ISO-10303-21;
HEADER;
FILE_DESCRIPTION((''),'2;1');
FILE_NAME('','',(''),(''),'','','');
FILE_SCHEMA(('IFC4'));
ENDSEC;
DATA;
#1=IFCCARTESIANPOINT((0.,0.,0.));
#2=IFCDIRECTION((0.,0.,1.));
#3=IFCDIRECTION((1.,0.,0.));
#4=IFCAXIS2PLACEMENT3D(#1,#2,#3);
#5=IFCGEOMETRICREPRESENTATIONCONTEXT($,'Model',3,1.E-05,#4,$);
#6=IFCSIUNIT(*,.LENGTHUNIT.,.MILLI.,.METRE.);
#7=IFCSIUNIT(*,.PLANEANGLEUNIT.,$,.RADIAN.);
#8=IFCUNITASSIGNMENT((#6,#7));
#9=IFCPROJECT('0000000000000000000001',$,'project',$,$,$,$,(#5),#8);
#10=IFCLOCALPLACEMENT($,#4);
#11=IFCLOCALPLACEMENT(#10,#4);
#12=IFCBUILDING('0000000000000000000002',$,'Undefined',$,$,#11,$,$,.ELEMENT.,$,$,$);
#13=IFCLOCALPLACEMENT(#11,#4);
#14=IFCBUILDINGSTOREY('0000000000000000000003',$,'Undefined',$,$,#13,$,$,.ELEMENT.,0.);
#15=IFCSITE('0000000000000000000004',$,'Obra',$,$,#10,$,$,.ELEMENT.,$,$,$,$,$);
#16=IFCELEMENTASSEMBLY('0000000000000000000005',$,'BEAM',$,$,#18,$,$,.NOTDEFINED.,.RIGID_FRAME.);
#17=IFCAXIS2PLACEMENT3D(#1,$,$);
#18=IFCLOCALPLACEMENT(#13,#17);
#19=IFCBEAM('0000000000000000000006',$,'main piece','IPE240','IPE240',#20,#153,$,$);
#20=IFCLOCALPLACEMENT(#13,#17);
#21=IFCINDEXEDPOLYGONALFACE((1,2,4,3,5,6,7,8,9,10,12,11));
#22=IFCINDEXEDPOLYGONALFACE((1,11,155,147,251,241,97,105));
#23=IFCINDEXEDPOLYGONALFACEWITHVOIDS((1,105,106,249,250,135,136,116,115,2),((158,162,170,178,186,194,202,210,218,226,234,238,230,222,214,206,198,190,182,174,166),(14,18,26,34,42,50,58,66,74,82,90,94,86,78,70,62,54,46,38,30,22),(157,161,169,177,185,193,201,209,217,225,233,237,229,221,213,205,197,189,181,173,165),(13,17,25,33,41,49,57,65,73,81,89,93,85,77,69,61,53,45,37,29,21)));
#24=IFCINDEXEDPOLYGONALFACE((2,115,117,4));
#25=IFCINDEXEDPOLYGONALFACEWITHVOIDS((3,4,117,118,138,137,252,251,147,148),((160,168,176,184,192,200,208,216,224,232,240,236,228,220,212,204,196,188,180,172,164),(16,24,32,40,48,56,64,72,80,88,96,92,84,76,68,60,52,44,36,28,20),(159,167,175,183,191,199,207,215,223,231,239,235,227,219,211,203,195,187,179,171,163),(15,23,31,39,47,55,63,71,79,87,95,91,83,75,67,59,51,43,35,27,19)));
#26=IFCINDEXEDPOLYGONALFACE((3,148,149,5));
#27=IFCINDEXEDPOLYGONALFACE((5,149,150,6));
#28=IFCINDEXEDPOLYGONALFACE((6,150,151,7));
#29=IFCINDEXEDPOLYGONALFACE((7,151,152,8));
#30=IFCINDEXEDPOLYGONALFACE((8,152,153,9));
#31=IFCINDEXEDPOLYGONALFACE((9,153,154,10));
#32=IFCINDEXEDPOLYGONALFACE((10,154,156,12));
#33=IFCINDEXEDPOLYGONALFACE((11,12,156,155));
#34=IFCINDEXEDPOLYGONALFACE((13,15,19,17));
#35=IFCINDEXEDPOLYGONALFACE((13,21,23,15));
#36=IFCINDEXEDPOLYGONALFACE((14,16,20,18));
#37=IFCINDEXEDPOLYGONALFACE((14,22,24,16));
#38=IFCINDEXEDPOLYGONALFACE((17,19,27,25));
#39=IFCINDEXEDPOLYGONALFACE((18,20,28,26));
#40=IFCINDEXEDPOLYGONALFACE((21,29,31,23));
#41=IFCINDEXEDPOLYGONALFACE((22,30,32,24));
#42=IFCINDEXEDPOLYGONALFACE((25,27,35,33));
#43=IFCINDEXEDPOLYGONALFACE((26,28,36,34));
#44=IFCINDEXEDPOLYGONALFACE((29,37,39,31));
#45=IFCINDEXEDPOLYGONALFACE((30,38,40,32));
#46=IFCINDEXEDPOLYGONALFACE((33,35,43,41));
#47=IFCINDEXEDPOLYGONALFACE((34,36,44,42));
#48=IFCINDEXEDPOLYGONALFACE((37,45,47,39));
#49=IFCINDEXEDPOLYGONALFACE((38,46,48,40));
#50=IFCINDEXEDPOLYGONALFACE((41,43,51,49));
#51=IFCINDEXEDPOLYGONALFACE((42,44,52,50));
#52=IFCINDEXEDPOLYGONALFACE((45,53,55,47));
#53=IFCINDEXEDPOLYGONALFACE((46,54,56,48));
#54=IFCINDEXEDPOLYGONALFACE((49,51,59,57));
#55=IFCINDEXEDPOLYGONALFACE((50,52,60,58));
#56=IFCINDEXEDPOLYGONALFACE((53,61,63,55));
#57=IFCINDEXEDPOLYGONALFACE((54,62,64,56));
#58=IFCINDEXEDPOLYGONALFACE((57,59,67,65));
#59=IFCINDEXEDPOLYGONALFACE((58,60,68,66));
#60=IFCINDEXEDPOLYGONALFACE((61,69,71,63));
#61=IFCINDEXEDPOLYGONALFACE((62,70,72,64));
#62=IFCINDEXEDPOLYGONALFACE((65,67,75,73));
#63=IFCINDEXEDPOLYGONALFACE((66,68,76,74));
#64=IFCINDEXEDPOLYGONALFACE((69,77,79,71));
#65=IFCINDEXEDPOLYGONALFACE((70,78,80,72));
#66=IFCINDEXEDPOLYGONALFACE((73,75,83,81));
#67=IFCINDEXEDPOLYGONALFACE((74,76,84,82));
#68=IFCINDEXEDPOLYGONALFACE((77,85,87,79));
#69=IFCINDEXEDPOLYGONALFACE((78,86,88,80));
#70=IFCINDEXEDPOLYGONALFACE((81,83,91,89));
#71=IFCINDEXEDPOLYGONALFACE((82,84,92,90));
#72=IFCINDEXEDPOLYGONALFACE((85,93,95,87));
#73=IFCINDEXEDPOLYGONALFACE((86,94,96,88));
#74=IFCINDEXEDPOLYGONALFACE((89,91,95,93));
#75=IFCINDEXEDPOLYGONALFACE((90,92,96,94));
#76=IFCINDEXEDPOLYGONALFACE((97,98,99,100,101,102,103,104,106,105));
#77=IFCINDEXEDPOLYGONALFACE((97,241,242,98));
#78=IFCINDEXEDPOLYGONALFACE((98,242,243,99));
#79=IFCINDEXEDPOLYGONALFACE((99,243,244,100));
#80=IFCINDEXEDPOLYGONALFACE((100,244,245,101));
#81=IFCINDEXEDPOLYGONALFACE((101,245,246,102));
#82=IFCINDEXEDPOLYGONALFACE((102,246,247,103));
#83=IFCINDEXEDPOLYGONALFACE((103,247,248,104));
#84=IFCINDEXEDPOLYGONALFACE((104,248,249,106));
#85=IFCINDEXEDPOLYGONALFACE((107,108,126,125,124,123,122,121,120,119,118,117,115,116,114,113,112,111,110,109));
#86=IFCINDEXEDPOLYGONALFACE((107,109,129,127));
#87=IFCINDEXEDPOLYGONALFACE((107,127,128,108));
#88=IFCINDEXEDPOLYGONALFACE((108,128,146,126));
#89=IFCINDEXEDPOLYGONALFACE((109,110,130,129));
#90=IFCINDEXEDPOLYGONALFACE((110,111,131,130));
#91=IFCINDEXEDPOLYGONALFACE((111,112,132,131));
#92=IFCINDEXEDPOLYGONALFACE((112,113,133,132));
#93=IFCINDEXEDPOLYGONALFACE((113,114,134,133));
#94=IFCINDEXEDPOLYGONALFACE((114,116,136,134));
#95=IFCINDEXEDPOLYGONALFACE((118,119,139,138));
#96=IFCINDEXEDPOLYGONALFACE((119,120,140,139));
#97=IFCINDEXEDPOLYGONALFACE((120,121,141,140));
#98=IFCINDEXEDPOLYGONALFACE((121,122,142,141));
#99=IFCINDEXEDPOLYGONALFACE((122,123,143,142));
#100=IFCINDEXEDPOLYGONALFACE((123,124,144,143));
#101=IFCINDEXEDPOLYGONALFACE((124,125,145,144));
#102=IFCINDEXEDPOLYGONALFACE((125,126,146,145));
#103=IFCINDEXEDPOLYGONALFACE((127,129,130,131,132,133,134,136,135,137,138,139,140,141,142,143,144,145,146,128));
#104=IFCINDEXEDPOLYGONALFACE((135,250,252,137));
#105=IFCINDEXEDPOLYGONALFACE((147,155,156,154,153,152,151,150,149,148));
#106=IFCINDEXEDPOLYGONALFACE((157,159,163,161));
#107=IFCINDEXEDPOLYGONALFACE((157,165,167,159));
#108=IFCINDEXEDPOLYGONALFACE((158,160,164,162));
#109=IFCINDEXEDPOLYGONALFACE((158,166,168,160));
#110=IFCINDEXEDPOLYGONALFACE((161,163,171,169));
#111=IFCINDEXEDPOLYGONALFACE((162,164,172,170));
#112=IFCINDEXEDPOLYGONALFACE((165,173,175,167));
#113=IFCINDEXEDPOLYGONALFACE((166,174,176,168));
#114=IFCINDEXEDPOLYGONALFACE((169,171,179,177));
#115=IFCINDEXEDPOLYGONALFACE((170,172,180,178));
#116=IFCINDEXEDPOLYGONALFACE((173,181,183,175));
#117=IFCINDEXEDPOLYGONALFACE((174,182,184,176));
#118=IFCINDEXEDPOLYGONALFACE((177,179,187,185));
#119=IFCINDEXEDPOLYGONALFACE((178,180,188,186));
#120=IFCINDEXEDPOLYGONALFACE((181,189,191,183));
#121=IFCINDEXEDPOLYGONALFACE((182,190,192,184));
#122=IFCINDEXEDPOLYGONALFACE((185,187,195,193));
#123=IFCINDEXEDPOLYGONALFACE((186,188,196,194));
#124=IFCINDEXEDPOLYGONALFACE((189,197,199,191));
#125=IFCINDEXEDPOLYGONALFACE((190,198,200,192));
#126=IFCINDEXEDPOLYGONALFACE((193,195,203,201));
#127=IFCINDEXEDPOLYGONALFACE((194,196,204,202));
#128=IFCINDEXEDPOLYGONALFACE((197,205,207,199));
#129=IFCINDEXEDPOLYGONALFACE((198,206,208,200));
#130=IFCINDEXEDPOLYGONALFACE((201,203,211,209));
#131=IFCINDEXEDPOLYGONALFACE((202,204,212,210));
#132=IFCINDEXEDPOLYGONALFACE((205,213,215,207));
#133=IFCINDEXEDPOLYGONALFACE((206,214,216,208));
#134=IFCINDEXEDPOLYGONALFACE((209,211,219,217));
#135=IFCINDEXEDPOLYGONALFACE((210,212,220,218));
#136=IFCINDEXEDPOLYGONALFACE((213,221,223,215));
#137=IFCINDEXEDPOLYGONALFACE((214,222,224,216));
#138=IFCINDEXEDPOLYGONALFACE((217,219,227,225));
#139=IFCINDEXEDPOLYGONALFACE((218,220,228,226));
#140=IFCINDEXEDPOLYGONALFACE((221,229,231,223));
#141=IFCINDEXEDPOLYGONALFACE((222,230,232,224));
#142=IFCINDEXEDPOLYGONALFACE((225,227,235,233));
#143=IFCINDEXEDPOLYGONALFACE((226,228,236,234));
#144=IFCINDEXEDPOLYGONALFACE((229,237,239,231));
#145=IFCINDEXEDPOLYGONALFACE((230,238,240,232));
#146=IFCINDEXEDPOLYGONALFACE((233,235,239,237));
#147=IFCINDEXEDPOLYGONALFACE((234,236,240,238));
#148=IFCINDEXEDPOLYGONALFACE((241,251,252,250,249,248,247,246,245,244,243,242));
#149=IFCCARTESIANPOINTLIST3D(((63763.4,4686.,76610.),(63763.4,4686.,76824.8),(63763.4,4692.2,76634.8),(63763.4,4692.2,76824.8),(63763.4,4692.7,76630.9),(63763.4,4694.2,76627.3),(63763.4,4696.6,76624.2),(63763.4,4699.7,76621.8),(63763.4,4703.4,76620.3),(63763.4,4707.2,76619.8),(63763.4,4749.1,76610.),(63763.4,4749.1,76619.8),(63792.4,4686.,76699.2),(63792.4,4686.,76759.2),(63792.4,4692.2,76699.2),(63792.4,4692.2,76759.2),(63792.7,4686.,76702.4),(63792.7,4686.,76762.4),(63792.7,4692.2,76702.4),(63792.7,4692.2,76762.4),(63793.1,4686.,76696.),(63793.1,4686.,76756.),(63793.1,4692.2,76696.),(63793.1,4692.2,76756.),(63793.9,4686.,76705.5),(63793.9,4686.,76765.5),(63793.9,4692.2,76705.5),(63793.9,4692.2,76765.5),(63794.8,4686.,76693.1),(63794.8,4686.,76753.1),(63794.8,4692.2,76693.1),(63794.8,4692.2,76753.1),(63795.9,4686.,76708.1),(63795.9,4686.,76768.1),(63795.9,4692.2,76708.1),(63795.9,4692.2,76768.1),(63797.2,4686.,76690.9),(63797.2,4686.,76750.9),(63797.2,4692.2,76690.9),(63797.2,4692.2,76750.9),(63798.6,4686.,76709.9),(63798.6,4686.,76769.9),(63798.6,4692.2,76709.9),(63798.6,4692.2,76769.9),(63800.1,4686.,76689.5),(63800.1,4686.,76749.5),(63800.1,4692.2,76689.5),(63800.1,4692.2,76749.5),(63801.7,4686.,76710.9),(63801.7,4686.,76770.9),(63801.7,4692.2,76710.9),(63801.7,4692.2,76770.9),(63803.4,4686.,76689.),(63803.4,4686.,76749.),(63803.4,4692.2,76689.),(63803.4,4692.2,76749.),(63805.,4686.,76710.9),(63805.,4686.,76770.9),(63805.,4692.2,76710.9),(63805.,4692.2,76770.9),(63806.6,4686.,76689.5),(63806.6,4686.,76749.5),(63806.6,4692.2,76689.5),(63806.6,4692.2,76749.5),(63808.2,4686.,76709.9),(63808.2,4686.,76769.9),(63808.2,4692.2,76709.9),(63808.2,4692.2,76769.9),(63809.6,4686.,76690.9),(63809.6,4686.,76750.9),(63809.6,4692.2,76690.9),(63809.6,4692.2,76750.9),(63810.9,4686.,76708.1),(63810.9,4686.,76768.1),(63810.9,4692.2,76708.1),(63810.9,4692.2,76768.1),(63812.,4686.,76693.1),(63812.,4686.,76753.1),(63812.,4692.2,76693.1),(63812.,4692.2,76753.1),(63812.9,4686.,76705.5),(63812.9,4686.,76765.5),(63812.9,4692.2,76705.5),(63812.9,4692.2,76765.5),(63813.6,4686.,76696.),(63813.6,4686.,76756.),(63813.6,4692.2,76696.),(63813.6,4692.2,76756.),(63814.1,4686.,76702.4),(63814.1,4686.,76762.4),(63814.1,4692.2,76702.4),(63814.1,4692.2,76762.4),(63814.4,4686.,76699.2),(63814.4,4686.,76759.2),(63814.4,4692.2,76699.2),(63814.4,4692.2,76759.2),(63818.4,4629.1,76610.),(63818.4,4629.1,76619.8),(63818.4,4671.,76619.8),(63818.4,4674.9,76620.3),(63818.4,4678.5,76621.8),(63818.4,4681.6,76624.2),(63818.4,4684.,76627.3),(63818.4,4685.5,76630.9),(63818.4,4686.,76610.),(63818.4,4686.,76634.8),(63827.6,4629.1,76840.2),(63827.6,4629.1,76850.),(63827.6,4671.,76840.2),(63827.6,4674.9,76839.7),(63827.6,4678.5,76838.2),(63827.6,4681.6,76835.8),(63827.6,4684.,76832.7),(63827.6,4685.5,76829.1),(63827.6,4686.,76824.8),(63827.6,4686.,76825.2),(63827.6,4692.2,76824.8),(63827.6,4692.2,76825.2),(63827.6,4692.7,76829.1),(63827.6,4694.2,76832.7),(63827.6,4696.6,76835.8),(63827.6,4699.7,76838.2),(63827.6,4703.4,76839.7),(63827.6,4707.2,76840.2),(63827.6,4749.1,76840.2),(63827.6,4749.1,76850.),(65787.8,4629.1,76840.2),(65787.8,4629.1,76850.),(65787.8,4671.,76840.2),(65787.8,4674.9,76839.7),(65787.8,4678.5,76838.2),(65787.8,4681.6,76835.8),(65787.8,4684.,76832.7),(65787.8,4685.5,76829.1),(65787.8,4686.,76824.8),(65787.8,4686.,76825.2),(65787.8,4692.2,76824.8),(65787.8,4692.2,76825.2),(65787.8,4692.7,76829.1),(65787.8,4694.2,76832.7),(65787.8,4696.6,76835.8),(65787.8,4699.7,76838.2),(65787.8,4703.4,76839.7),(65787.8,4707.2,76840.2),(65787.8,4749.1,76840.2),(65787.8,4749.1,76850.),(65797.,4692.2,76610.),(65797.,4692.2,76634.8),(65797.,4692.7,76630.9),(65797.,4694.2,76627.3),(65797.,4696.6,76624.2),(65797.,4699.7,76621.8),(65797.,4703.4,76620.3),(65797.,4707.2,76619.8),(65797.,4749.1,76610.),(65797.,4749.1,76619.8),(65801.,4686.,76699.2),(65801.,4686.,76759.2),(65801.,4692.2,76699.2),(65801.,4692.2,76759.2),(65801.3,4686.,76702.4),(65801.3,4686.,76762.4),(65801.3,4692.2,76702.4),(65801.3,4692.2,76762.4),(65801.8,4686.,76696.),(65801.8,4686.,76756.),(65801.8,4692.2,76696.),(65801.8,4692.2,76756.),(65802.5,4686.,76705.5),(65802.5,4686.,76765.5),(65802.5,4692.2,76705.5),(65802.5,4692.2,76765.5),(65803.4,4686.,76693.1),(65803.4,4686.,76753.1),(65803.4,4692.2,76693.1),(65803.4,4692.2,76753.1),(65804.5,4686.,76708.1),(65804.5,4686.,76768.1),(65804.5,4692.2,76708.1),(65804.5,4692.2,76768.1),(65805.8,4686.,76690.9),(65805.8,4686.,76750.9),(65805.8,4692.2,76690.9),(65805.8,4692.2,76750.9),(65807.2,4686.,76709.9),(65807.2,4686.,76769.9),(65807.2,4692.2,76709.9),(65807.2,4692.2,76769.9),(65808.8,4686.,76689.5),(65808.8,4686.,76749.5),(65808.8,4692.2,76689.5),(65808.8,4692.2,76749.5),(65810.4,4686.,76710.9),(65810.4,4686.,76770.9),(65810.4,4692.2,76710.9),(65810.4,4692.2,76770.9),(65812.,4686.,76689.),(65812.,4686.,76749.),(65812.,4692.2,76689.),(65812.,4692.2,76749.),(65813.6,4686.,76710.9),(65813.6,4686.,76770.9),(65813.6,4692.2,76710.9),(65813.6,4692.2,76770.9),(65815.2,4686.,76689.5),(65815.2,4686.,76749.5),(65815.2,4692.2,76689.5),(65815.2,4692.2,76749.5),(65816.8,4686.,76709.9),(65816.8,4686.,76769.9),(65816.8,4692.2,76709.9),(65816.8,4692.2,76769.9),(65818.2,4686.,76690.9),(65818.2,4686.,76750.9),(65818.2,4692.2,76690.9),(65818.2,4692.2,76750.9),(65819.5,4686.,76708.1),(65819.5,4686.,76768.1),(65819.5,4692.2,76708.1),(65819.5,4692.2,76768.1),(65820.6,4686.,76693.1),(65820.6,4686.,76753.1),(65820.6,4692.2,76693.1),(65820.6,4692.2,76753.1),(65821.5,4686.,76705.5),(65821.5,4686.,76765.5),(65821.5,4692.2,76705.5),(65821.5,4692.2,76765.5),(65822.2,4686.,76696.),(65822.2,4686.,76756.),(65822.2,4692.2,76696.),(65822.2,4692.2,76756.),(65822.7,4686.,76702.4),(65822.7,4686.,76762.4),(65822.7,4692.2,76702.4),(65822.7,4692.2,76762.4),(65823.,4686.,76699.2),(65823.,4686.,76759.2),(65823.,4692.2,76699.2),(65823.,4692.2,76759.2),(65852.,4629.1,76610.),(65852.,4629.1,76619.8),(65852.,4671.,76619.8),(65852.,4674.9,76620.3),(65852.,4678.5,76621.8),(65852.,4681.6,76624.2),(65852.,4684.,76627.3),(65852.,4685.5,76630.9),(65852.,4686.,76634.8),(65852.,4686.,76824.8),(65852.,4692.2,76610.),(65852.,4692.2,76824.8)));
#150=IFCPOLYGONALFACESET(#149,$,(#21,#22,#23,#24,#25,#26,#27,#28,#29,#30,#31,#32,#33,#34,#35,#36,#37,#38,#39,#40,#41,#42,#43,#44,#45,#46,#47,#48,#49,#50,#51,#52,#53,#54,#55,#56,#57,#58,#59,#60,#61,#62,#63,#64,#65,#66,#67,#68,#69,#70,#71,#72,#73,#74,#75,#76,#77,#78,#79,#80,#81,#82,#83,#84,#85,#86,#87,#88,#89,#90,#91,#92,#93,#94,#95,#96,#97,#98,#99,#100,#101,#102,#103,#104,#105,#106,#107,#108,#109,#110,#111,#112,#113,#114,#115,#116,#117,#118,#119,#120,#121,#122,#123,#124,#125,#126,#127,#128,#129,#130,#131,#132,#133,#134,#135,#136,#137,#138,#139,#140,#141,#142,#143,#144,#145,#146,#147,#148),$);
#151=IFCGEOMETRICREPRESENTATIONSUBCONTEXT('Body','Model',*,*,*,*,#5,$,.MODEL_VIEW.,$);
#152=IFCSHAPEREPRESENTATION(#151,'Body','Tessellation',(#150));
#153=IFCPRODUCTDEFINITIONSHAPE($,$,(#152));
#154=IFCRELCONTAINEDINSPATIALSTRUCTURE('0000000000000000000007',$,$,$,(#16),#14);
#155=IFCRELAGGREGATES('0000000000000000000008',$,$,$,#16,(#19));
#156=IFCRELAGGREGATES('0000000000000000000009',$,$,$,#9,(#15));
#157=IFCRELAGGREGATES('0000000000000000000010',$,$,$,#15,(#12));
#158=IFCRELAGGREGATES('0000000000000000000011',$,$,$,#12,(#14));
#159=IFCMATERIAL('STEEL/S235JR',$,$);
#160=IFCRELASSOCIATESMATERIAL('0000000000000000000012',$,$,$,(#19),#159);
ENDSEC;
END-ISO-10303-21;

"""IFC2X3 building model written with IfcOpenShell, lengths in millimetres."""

from ifc_helpers import new_model, si_unit, frame, origin_with_axes, origin_2d_with_axis, place, context, subcontext, project, spatial, rectangle, circle, i_section, extrude, clip, halfspace, source, transform, mapped, material, element, aggregate, save


model = new_model("IFC2X3")

# Units and contexts
model_context = context("Model", 3, precision=1e-05, world=origin_with_axes())
body_context = subcontext(model_context, "Body", "Model", "MODEL_VIEW")
ifc_project = project(units=[si_unit("LENGTHUNIT", "METRE", prefix="MILLI"), si_unit("PLANEANGLEUNIT", "RADIAN")], contexts=[model_context])

# Site, building, storey
site_placement = place(None, origin_with_axes())
site = spatial("IfcSite", under=ifc_project, at=site_placement, Name="Obra", CompositionType="ELEMENT")
building_placement = place(site_placement, origin_with_axes())
building = spatial("IfcBuilding", under=site, at=building_placement, Name="Undefined", CompositionType="ELEMENT")
storey_placement = place(building_placement, origin_with_axes())
storey = spatial("IfcBuildingStorey", under=building, at=storey_placement, Name="Undefined", CompositionType="ELEMENT", Elevation=0.0)

# Element assembly, beam, openings
ifc_material_1 = material(Name="STEEL/S235JR")
shared_shape_1 = source(origin_with_axes(), body_context, "Body", "SweptSolid", [
    extrude(circle(Radius=11.0, at=origin_2d_with_axis()), frame((0.0, -3.2, 0.0), z_axis=(0.0, 1.0, 0.0), x_axis=(1.0, 0.0, 0.0)), (0.0, 0.0, 1.0), 6.4),
])
assembly_1_placement = place(storey_placement, origin_with_axes())
assembly_1 = element("IfcElementAssembly", 1, at=assembly_1_placement, inside=storey, Name="BEAM", AssemblyPlace="NOTDEFINED", PredefinedType="RIGID_FRAME")
beam_1_placement = place(assembly_1_placement, frame((65797.8, 4689.1, 76730.0), z_axis=(0.0, 0.0, 1.0), x_axis=(-1.0, 0.0, 0.0)))
beam_1 = element("IfcBeam", 2, at=beam_1_placement, material=ifc_material_1, Name="main piece", Description="IPE240", ObjectType="IPE240", context=body_context, shape_type="Clipping", body=[
    clip(clip(extrude(i_section(OverallWidth=120.0, OverallDepth=240.0, WebThickness=6.2, FlangeThickness=9.8, FilletRadius=15.0, at=origin_2d_with_axis()), frame((2034.4, 0.0, 0.0), z_axis=(-1.0, 0.0, 0.0), x_axis=(0.0, -1.0, 0.0)), (0.0, 0.0, 1.0), 2088.6), halfspace(frame((2034.4, 0.0, -220.0), z_axis=(-1.0, 0.0, 0.0), x_axis=(0.0, 1.0, 0.0)), True)), halfspace(frame((-54.2, 0.0, -220.0), z_axis=(1.0, 0.0, 0.0), x_axis=(0.0, -1.0, 0.0)), True)),
])
opening_1_placement = place(assembly_1_placement, frame((65797.8, 4689.1, 76730.0), z_axis=(0.0, 0.0, 1.0), x_axis=(-1.0, 0.0, 0.0)))
element("IfcOpeningElement", 3, at=opening_1_placement, cuts=beam_1, ObjectType="Recess", context=body_context, shape_type="SweptSolid", body=[
    extrude(rectangle(XDim=65.0, YDim=300.0, at=origin_2d_with_axis()), frame((-31.7, -153.1, 109.8), z_axis=(0.0, 0.0, -1.0), x_axis=(1.0, 0.0, 0.0)), (0.0, 0.0, 1.0), 249.6),
])
opening_2_placement = place(assembly_1_placement, frame((65797.8, 4689.1, 76730.0), z_axis=(0.0, 0.0, 1.0), x_axis=(-1.0, 0.0, 0.0)))
element("IfcOpeningElement", 4, at=opening_2_placement, cuts=beam_1, ObjectType="Recess", context=body_context, shape_type="SweptSolid", body=[
    extrude(rectangle(XDim=26.2, YDim=76.2, at=origin_2d_with_axis()), frame((-28.1, -61.0, 107.9), z_axis=(0.0, 1.0, 0.0), x_axis=(0.0, 0.0, -1.0)), (0.0, 0.0, 1.0), 122.0),
])
opening_3_placement = place(assembly_1_placement, frame((65797.8, 4689.1, 76730.0), z_axis=(0.0, 0.0, 1.0), x_axis=(-1.0, 0.0, 0.0)))
element("IfcOpeningElement", 5, at=opening_3_placement, cuts=beam_1, ObjectType="Recess", context=body_context, shape_type="SweptSolid", body=[
    extrude(rectangle(XDim=65.0, YDim=300.0, at=origin_2d_with_axis()), frame((2011.9, 153.1, 109.8), z_axis=(0.0, 0.0, -1.0), x_axis=(-1.0, 0.0, 0.0)), (0.0, 0.0, 1.0), 249.6),
])
opening_4_placement = place(assembly_1_placement, frame((65797.8, 4689.1, 76730.0), z_axis=(0.0, 0.0, 1.0), x_axis=(-1.0, 0.0, 0.0)))
element("IfcOpeningElement", 6, at=opening_4_placement, cuts=beam_1, ObjectType="Recess", context=body_context, shape_type="SweptSolid", body=[
    extrude(rectangle(XDim=26.2, YDim=76.2, at=origin_2d_with_axis()), frame((2008.3, 61.0, 107.9), z_axis=(0.0, -1.0, 0.0), x_axis=(0.0, 0.0, -1.0)), (0.0, 0.0, 1.0), 122.0),
])
opening_5_placement = place(assembly_1_placement, frame((65852.0, 4689.1, 76850.0), z_axis=(-1.0, 0.0, 0.0), x_axis=(0.0, 0.0, -1.0)))
element("IfcOpeningElement", 7, at=opening_5_placement, cuts=beam_1, ObjectType="Opening", context=body_context, shape_type="MappedRepresentation", body=[
    mapped(shared_shape_1, transform((90.0, 0.0, 40.0))),
    mapped(shared_shape_1, transform((150.0, 0.0, 40.0))),
])
opening_6_placement = place(assembly_1_placement, frame((63763.4, 4689.1, 76850.0), z_axis=(1.0, 0.0, 0.0), x_axis=(0.0, 0.0, -1.0)))
element("IfcOpeningElement", 8, at=opening_6_placement, cuts=beam_1, ObjectType="Opening", context=body_context, shape_type="MappedRepresentation", body=[
    mapped(shared_shape_1, transform((90.0, 0.0, 40.0))),
    mapped(shared_shape_1, transform((150.0, 0.0, 40.0))),
])

aggregate(assembly_1, [beam_1])

save(model, "model.ifc")
